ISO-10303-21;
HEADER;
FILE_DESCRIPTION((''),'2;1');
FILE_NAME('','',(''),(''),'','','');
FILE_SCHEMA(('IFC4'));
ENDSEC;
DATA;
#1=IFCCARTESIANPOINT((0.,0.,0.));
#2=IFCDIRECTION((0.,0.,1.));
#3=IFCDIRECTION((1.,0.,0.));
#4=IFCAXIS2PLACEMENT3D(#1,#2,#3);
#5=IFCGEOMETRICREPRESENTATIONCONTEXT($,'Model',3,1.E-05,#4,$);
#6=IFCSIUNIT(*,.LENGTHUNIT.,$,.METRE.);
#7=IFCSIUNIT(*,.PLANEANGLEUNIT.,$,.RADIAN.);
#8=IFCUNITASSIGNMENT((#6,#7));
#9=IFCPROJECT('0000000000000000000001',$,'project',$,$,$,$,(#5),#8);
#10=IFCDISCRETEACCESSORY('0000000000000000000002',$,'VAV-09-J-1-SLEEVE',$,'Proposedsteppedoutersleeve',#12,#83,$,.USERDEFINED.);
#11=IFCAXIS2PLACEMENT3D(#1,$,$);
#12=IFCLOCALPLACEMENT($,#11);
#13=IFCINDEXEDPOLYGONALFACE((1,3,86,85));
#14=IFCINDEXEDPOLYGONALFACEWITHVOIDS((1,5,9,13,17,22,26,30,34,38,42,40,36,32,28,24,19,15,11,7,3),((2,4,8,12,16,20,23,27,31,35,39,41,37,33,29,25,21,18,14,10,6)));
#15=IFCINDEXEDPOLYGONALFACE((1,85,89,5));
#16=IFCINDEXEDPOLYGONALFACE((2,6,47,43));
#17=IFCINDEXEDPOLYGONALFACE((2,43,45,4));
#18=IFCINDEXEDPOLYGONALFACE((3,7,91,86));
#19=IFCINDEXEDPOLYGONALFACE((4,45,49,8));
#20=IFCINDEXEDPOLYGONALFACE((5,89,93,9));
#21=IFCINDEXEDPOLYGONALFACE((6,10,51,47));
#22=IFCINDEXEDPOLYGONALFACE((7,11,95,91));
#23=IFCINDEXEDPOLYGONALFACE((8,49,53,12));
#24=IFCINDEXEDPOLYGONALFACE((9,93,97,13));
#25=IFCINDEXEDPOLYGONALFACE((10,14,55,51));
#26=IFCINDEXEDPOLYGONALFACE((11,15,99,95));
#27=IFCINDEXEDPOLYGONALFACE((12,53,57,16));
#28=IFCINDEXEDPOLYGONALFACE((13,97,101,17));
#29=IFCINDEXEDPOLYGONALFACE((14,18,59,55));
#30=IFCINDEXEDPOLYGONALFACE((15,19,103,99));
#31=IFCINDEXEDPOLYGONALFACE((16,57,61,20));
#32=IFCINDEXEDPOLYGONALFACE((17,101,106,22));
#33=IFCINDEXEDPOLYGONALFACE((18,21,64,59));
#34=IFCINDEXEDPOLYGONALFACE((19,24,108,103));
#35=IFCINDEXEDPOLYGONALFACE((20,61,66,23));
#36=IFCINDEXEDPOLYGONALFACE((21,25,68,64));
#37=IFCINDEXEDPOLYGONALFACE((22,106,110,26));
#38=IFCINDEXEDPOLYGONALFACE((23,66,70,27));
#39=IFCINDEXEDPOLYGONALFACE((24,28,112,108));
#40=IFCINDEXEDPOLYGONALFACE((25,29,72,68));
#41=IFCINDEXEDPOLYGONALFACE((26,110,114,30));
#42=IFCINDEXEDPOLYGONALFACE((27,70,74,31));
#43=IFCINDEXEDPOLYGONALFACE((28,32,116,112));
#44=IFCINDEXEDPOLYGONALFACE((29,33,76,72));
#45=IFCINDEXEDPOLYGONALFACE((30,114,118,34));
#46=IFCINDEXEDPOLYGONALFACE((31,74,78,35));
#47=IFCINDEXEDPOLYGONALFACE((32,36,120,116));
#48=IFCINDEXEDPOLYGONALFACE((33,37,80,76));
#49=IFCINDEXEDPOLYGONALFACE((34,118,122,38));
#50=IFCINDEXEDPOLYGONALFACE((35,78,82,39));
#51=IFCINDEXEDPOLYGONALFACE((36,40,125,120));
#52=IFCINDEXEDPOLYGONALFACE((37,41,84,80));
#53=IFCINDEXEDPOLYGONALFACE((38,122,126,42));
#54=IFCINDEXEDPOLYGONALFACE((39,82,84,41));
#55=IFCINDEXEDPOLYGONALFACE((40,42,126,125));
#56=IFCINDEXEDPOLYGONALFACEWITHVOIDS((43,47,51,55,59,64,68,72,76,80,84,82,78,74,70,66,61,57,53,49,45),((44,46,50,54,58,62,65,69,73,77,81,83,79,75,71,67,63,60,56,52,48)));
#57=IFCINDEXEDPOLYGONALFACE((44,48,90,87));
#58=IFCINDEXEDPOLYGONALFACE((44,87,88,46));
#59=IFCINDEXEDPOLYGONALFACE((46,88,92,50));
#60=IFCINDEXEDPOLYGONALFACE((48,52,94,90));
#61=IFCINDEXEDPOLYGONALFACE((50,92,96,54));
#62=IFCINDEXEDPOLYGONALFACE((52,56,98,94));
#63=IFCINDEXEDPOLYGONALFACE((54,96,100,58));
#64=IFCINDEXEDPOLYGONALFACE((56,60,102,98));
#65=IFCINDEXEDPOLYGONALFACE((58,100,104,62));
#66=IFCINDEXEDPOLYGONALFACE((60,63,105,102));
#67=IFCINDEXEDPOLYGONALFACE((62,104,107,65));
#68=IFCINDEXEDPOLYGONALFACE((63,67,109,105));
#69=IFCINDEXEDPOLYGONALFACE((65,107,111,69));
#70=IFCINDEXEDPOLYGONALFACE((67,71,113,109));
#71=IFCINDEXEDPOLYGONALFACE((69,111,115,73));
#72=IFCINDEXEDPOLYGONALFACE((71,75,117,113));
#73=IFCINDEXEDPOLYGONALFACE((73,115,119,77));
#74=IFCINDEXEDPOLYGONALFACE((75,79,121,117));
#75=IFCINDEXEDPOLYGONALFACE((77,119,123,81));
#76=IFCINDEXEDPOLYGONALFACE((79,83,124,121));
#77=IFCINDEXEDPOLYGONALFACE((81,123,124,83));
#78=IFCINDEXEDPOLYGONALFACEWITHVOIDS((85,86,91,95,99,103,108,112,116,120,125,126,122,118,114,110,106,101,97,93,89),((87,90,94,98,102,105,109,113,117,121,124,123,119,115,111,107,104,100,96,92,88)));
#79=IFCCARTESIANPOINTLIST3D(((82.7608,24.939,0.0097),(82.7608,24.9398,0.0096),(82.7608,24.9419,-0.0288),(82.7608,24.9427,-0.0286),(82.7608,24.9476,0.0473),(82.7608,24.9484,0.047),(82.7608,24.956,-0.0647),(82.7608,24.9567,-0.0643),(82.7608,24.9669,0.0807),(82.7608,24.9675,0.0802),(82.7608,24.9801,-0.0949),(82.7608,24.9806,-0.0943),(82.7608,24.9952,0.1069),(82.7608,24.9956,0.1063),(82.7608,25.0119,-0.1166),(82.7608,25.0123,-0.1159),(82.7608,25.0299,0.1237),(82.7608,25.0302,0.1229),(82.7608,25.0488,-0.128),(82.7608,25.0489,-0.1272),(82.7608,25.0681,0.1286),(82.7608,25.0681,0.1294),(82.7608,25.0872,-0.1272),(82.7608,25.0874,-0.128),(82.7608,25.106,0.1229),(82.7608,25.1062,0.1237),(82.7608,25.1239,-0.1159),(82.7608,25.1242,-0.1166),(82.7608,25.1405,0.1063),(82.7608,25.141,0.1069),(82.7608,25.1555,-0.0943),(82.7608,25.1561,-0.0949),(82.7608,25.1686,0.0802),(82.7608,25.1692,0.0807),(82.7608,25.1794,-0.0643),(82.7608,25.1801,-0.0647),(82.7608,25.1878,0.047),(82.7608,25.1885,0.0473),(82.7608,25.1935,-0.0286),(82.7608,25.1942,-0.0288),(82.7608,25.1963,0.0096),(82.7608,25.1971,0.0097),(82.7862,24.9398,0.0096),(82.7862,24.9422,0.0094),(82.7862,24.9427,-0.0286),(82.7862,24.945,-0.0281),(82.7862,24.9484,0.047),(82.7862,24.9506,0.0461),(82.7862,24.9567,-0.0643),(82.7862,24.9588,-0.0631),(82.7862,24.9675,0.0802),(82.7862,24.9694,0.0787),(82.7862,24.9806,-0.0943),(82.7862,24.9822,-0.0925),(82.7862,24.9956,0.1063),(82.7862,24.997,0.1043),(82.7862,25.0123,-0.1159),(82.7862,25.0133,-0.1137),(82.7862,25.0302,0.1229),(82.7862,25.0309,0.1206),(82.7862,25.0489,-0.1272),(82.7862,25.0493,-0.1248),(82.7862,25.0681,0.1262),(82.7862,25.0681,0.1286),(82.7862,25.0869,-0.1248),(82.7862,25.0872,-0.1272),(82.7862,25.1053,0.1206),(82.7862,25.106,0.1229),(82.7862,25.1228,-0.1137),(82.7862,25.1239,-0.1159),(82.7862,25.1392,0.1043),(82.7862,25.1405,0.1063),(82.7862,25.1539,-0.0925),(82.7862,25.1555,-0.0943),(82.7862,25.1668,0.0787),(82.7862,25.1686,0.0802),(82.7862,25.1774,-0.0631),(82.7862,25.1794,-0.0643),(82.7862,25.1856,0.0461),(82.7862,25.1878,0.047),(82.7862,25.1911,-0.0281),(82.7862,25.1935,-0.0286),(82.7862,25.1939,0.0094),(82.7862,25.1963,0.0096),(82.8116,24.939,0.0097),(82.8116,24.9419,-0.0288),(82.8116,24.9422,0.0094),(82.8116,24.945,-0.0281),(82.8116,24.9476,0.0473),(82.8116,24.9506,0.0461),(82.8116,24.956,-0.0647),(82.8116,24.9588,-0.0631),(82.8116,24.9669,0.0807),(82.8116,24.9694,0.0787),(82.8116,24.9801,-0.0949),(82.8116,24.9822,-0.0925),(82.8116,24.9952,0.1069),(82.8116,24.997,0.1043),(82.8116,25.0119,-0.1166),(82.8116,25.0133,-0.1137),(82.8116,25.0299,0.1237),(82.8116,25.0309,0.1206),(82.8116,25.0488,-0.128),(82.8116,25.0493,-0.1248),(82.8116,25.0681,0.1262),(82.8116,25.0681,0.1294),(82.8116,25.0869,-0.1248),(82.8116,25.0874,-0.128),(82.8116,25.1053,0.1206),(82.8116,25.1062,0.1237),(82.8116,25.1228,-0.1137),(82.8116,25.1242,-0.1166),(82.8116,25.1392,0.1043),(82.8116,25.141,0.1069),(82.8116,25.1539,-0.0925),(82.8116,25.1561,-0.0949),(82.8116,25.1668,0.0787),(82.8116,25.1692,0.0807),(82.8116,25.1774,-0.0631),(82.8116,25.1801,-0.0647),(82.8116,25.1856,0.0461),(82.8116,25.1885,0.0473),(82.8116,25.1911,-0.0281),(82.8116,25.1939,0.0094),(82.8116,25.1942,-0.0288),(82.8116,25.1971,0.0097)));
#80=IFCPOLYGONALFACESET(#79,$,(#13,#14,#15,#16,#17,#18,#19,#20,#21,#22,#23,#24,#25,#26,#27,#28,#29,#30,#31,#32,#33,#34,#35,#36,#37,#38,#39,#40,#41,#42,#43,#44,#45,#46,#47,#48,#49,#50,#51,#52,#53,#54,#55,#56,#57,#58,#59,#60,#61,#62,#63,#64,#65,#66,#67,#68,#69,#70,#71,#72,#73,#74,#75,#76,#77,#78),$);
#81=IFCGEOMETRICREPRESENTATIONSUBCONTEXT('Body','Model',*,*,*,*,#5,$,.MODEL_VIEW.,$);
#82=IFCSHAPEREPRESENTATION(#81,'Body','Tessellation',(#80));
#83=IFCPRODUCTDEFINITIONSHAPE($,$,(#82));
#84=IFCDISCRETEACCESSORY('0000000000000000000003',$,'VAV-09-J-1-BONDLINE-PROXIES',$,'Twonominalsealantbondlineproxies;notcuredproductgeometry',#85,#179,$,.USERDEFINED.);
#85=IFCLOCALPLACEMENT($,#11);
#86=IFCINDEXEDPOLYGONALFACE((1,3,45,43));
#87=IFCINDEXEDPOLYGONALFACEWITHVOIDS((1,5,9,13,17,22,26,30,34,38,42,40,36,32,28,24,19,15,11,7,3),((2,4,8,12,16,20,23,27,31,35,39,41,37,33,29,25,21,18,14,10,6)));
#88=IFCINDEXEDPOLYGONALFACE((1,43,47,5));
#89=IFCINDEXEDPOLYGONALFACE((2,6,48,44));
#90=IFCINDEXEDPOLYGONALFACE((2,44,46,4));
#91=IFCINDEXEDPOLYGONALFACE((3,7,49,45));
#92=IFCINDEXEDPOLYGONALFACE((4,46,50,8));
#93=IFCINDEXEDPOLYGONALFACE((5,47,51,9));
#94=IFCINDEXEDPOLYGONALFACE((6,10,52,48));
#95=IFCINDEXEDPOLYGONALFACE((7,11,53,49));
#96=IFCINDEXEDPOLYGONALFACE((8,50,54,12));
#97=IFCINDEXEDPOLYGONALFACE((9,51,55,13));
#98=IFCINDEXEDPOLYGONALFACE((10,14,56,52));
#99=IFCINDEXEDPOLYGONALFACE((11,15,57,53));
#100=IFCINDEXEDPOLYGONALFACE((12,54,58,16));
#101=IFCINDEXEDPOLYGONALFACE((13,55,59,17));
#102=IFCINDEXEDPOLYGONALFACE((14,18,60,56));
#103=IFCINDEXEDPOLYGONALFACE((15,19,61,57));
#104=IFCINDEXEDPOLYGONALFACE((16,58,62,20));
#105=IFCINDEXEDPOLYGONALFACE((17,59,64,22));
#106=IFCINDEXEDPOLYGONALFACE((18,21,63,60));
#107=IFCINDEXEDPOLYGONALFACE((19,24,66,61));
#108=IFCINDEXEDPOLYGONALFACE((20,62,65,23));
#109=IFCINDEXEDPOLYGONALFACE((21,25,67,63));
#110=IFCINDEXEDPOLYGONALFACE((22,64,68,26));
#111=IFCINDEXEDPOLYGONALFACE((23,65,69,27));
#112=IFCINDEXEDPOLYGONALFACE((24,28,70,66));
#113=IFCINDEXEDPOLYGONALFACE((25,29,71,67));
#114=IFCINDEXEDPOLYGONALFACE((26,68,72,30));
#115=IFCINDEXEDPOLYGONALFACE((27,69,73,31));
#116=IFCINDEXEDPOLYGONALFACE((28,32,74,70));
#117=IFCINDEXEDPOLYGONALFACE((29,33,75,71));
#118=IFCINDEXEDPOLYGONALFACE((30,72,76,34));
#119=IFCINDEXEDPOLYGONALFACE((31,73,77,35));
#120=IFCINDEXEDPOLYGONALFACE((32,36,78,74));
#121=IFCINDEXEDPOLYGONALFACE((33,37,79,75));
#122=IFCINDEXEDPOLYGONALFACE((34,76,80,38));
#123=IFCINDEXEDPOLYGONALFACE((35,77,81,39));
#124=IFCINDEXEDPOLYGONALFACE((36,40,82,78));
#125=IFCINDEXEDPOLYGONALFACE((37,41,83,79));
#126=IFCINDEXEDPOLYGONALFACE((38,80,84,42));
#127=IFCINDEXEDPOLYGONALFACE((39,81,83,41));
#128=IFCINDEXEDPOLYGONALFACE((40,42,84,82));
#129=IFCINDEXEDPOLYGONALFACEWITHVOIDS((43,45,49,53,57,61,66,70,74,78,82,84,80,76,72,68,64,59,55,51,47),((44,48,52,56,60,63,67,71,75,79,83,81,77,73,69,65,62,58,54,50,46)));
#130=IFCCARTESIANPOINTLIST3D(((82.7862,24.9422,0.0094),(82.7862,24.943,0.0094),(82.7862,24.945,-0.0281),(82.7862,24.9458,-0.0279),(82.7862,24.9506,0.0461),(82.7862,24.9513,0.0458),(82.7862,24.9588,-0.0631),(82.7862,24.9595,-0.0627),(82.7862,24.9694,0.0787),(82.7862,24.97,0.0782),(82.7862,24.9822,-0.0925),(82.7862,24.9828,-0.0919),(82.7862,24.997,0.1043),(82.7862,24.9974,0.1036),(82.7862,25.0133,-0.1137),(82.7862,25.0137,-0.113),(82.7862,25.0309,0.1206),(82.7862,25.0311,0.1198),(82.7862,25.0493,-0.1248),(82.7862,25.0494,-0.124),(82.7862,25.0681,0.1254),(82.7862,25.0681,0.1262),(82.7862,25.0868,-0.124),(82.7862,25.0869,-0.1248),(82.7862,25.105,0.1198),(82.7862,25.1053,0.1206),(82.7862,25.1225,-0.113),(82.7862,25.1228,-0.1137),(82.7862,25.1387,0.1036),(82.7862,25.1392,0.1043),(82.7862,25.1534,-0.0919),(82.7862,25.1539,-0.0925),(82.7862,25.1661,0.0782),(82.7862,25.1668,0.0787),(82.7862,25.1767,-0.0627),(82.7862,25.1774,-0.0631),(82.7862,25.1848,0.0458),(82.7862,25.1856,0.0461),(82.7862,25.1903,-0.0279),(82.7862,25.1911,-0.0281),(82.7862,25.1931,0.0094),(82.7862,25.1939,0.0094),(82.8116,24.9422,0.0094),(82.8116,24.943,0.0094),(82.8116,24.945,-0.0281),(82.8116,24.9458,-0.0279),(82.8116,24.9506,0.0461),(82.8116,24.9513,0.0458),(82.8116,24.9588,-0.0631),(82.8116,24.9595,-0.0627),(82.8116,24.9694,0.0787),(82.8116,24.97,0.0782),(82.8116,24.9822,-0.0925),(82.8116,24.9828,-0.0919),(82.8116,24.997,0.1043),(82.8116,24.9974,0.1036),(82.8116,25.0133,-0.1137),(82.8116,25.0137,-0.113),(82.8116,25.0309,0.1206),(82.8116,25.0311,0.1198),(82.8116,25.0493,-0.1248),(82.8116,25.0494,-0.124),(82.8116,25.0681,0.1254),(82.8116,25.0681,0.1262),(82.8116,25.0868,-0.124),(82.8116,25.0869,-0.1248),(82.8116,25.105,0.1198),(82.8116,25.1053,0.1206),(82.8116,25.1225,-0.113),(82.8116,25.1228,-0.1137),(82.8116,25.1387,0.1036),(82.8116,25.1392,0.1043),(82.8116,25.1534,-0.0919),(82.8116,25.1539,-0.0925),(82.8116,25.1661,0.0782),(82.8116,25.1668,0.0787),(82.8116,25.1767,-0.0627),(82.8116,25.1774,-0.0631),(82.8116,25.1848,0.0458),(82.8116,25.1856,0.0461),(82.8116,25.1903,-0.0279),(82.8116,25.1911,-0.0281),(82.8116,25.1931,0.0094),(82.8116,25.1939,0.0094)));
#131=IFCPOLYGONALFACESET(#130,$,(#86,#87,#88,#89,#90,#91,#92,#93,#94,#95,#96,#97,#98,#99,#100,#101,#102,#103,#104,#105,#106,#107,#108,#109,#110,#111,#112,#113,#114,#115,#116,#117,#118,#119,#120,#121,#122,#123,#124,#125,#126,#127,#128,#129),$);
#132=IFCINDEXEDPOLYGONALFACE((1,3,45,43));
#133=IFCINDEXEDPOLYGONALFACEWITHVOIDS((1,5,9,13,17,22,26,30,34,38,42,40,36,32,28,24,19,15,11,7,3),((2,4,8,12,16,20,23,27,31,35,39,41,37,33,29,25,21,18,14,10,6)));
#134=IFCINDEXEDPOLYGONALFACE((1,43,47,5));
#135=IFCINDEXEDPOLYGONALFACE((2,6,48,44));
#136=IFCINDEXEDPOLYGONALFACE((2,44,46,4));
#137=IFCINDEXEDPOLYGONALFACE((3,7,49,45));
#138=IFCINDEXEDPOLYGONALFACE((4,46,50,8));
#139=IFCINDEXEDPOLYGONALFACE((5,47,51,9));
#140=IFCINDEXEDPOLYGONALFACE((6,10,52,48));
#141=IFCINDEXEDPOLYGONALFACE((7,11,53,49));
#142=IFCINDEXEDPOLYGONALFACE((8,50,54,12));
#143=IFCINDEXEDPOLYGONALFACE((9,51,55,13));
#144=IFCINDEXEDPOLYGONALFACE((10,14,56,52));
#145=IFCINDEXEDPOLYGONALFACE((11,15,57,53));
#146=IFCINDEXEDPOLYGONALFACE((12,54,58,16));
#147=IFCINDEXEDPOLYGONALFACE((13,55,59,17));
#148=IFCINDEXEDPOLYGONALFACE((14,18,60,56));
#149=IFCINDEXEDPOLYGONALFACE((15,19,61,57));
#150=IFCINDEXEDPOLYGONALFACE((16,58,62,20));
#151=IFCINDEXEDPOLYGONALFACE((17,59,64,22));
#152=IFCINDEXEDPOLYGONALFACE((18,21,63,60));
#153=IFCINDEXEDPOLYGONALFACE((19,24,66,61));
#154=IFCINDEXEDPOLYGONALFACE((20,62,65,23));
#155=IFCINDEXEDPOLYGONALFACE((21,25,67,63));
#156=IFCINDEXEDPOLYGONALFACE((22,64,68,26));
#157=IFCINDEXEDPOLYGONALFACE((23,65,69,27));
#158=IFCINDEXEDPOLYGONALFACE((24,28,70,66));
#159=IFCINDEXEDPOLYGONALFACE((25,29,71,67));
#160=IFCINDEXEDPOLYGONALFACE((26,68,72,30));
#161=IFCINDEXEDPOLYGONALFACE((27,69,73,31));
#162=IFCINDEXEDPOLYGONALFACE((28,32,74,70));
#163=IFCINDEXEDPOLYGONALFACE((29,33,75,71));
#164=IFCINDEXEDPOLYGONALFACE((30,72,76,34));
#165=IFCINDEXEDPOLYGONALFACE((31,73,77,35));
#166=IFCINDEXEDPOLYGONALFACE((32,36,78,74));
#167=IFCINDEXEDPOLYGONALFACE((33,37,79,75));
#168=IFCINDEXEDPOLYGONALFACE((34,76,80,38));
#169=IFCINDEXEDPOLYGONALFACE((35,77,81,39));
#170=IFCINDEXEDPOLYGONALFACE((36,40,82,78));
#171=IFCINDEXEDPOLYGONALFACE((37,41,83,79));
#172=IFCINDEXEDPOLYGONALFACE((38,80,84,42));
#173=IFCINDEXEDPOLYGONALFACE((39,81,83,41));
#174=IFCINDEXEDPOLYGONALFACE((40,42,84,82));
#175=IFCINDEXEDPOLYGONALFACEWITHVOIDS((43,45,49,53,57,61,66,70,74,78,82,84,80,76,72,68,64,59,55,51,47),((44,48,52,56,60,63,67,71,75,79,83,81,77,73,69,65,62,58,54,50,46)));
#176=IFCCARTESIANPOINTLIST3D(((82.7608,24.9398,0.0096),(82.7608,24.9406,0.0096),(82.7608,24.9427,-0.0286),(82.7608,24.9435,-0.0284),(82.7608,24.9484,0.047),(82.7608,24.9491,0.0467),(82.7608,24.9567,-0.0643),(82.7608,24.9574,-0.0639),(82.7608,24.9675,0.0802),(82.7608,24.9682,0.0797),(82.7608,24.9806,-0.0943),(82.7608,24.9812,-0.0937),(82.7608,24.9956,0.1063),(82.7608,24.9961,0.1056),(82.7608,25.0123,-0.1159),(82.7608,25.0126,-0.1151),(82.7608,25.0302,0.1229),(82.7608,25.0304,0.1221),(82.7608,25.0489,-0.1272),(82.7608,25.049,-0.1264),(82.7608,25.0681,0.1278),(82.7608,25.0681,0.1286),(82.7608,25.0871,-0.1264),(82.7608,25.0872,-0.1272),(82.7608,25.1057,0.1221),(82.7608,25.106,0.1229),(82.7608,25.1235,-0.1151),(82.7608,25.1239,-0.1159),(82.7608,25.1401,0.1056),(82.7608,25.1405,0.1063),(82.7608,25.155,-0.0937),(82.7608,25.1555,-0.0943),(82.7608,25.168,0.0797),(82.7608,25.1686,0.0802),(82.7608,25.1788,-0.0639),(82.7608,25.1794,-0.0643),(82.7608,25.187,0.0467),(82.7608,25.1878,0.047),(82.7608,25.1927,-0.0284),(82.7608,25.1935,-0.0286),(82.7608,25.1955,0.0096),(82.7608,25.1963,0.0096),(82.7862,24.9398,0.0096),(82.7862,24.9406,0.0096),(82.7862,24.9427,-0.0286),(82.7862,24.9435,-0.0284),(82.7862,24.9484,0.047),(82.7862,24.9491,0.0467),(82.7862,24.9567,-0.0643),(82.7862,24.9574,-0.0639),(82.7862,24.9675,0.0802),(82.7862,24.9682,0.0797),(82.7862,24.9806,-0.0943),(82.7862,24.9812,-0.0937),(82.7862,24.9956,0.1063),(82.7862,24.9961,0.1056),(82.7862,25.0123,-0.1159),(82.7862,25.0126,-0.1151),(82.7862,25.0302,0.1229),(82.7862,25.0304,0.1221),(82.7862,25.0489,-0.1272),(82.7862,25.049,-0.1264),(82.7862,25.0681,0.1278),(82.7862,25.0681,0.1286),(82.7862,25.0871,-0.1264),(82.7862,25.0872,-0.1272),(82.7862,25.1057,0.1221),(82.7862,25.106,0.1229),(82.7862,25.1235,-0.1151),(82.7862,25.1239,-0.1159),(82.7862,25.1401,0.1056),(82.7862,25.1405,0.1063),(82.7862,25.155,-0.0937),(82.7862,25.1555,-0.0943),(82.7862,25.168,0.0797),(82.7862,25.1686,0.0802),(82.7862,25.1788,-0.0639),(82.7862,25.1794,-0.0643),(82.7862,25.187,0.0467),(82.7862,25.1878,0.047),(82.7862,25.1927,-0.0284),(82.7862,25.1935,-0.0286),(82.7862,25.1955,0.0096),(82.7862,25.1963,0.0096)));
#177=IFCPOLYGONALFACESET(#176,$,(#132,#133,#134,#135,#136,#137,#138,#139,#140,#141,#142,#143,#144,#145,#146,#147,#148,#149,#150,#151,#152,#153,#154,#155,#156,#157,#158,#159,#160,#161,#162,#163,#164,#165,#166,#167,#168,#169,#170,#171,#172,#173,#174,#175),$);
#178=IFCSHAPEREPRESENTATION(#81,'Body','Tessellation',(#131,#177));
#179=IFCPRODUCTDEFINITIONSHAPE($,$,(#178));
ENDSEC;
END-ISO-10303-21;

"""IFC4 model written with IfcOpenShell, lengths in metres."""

from ifc_helpers import new_model, entity, si_unit, frame, origin_with_axes, place, context, subcontext, project, element, save


model = new_model("IFC4")

# Units and contexts
model_context = context("Model", 3, precision=1e-05, world=origin_with_axes())
body_context = subcontext(model_context, "Body", "Model", "MODEL_VIEW")
ifc_project = project(units=[si_unit("LENGTHUNIT", "METRE"), si_unit("PLANEANGLEUNIT", "RADIAN")], contexts=[model_context])

# Discrete accessories
discrete_accessory_1_placement = place(None, frame((82.7862, 25.0681, 0.0), z_axis=(0.0, -1.0, 0.0), x_axis=(0.0, 0.0, 1.0)))
element("IfcDiscreteAccessory", 1, at=discrete_accessory_1_placement, Name="VAV-09-J-1-SLEEVE", ObjectType="Proposedsteppedoutersleeve", PredefinedType="USERDEFINED", context=body_context, shape_type="SweptSolid", body=[
    entity("IfcRevolvedAreaSolid", entity("IfcArbitraryClosedProfileDef", "AREA", None, entity("IfcPolyline", [entity("IfcCartesianPoint", [0.1262, -0.0254]), entity("IfcCartesianPoint", [0.1294, -0.0254]), entity("IfcCartesianPoint", [0.1294, 0.0254]), entity("IfcCartesianPoint", [0.1286, 0.0254]), entity("IfcCartesianPoint", [0.1286, 0.0]), entity("IfcCartesianPoint", [0.1262, 0.0]), entity("IfcCartesianPoint", [0.1262, -0.0254])])), entity("IfcAxis2Placement3D", entity("IfcCartesianPoint", [0.0, 0.0, 0.0])), entity("IfcAxis1Placement", entity("IfcCartesianPoint", [0.0, 0.0, 0.0]), entity("IfcDirection", [0.0, 1.0, 0.0])), 6.283185),
])
discrete_accessory_2_placement = place(None, frame((82.7862, 25.0681, 0.0), z_axis=(0.0, -1.0, 0.0), x_axis=(0.0, 0.0, 1.0)))
element("IfcDiscreteAccessory", 2, at=discrete_accessory_2_placement, Name="VAV-09-J-1-BONDLINE-PROXIES", ObjectType="Twonominalsealantbondlineproxies;notcuredproductgeometry", PredefinedType="USERDEFINED", context=body_context, shape_type="SweptSolid", body=[
    entity("IfcRevolvedAreaSolid", entity("IfcArbitraryClosedProfileDef", "AREA", None, entity("IfcPolyline", [entity("IfcCartesianPoint", [0.1254, -0.0254]), entity("IfcCartesianPoint", [0.1262, -0.0254]), entity("IfcCartesianPoint", [0.1262, 0.0]), entity("IfcCartesianPoint", [0.1254, 0.0]), entity("IfcCartesianPoint", [0.1254, -0.0254])])), entity("IfcAxis2Placement3D", entity("IfcCartesianPoint", [0.0, 0.0, 0.0])), entity("IfcAxis1Placement", entity("IfcCartesianPoint", [0.0, 0.0, 0.0]), entity("IfcDirection", [0.0, 1.0, 0.0])), 6.283185),
    entity("IfcRevolvedAreaSolid", entity("IfcArbitraryClosedProfileDef", "AREA", None, entity("IfcPolyline", [entity("IfcCartesianPoint", [0.1278, 0.0]), entity("IfcCartesianPoint", [0.1286, 0.0]), entity("IfcCartesianPoint", [0.1286, 0.0254]), entity("IfcCartesianPoint", [0.1278, 0.0254]), entity("IfcCartesianPoint", [0.1278, 0.0])])), entity("IfcAxis2Placement3D", entity("IfcCartesianPoint", [0.0, 0.0, 0.0])), entity("IfcAxis1Placement", entity("IfcCartesianPoint", [0.0, 0.0, 0.0]), entity("IfcDirection", [0.0, 1.0, 0.0])), 6.283185),
])

save(model, "model.ifc")
